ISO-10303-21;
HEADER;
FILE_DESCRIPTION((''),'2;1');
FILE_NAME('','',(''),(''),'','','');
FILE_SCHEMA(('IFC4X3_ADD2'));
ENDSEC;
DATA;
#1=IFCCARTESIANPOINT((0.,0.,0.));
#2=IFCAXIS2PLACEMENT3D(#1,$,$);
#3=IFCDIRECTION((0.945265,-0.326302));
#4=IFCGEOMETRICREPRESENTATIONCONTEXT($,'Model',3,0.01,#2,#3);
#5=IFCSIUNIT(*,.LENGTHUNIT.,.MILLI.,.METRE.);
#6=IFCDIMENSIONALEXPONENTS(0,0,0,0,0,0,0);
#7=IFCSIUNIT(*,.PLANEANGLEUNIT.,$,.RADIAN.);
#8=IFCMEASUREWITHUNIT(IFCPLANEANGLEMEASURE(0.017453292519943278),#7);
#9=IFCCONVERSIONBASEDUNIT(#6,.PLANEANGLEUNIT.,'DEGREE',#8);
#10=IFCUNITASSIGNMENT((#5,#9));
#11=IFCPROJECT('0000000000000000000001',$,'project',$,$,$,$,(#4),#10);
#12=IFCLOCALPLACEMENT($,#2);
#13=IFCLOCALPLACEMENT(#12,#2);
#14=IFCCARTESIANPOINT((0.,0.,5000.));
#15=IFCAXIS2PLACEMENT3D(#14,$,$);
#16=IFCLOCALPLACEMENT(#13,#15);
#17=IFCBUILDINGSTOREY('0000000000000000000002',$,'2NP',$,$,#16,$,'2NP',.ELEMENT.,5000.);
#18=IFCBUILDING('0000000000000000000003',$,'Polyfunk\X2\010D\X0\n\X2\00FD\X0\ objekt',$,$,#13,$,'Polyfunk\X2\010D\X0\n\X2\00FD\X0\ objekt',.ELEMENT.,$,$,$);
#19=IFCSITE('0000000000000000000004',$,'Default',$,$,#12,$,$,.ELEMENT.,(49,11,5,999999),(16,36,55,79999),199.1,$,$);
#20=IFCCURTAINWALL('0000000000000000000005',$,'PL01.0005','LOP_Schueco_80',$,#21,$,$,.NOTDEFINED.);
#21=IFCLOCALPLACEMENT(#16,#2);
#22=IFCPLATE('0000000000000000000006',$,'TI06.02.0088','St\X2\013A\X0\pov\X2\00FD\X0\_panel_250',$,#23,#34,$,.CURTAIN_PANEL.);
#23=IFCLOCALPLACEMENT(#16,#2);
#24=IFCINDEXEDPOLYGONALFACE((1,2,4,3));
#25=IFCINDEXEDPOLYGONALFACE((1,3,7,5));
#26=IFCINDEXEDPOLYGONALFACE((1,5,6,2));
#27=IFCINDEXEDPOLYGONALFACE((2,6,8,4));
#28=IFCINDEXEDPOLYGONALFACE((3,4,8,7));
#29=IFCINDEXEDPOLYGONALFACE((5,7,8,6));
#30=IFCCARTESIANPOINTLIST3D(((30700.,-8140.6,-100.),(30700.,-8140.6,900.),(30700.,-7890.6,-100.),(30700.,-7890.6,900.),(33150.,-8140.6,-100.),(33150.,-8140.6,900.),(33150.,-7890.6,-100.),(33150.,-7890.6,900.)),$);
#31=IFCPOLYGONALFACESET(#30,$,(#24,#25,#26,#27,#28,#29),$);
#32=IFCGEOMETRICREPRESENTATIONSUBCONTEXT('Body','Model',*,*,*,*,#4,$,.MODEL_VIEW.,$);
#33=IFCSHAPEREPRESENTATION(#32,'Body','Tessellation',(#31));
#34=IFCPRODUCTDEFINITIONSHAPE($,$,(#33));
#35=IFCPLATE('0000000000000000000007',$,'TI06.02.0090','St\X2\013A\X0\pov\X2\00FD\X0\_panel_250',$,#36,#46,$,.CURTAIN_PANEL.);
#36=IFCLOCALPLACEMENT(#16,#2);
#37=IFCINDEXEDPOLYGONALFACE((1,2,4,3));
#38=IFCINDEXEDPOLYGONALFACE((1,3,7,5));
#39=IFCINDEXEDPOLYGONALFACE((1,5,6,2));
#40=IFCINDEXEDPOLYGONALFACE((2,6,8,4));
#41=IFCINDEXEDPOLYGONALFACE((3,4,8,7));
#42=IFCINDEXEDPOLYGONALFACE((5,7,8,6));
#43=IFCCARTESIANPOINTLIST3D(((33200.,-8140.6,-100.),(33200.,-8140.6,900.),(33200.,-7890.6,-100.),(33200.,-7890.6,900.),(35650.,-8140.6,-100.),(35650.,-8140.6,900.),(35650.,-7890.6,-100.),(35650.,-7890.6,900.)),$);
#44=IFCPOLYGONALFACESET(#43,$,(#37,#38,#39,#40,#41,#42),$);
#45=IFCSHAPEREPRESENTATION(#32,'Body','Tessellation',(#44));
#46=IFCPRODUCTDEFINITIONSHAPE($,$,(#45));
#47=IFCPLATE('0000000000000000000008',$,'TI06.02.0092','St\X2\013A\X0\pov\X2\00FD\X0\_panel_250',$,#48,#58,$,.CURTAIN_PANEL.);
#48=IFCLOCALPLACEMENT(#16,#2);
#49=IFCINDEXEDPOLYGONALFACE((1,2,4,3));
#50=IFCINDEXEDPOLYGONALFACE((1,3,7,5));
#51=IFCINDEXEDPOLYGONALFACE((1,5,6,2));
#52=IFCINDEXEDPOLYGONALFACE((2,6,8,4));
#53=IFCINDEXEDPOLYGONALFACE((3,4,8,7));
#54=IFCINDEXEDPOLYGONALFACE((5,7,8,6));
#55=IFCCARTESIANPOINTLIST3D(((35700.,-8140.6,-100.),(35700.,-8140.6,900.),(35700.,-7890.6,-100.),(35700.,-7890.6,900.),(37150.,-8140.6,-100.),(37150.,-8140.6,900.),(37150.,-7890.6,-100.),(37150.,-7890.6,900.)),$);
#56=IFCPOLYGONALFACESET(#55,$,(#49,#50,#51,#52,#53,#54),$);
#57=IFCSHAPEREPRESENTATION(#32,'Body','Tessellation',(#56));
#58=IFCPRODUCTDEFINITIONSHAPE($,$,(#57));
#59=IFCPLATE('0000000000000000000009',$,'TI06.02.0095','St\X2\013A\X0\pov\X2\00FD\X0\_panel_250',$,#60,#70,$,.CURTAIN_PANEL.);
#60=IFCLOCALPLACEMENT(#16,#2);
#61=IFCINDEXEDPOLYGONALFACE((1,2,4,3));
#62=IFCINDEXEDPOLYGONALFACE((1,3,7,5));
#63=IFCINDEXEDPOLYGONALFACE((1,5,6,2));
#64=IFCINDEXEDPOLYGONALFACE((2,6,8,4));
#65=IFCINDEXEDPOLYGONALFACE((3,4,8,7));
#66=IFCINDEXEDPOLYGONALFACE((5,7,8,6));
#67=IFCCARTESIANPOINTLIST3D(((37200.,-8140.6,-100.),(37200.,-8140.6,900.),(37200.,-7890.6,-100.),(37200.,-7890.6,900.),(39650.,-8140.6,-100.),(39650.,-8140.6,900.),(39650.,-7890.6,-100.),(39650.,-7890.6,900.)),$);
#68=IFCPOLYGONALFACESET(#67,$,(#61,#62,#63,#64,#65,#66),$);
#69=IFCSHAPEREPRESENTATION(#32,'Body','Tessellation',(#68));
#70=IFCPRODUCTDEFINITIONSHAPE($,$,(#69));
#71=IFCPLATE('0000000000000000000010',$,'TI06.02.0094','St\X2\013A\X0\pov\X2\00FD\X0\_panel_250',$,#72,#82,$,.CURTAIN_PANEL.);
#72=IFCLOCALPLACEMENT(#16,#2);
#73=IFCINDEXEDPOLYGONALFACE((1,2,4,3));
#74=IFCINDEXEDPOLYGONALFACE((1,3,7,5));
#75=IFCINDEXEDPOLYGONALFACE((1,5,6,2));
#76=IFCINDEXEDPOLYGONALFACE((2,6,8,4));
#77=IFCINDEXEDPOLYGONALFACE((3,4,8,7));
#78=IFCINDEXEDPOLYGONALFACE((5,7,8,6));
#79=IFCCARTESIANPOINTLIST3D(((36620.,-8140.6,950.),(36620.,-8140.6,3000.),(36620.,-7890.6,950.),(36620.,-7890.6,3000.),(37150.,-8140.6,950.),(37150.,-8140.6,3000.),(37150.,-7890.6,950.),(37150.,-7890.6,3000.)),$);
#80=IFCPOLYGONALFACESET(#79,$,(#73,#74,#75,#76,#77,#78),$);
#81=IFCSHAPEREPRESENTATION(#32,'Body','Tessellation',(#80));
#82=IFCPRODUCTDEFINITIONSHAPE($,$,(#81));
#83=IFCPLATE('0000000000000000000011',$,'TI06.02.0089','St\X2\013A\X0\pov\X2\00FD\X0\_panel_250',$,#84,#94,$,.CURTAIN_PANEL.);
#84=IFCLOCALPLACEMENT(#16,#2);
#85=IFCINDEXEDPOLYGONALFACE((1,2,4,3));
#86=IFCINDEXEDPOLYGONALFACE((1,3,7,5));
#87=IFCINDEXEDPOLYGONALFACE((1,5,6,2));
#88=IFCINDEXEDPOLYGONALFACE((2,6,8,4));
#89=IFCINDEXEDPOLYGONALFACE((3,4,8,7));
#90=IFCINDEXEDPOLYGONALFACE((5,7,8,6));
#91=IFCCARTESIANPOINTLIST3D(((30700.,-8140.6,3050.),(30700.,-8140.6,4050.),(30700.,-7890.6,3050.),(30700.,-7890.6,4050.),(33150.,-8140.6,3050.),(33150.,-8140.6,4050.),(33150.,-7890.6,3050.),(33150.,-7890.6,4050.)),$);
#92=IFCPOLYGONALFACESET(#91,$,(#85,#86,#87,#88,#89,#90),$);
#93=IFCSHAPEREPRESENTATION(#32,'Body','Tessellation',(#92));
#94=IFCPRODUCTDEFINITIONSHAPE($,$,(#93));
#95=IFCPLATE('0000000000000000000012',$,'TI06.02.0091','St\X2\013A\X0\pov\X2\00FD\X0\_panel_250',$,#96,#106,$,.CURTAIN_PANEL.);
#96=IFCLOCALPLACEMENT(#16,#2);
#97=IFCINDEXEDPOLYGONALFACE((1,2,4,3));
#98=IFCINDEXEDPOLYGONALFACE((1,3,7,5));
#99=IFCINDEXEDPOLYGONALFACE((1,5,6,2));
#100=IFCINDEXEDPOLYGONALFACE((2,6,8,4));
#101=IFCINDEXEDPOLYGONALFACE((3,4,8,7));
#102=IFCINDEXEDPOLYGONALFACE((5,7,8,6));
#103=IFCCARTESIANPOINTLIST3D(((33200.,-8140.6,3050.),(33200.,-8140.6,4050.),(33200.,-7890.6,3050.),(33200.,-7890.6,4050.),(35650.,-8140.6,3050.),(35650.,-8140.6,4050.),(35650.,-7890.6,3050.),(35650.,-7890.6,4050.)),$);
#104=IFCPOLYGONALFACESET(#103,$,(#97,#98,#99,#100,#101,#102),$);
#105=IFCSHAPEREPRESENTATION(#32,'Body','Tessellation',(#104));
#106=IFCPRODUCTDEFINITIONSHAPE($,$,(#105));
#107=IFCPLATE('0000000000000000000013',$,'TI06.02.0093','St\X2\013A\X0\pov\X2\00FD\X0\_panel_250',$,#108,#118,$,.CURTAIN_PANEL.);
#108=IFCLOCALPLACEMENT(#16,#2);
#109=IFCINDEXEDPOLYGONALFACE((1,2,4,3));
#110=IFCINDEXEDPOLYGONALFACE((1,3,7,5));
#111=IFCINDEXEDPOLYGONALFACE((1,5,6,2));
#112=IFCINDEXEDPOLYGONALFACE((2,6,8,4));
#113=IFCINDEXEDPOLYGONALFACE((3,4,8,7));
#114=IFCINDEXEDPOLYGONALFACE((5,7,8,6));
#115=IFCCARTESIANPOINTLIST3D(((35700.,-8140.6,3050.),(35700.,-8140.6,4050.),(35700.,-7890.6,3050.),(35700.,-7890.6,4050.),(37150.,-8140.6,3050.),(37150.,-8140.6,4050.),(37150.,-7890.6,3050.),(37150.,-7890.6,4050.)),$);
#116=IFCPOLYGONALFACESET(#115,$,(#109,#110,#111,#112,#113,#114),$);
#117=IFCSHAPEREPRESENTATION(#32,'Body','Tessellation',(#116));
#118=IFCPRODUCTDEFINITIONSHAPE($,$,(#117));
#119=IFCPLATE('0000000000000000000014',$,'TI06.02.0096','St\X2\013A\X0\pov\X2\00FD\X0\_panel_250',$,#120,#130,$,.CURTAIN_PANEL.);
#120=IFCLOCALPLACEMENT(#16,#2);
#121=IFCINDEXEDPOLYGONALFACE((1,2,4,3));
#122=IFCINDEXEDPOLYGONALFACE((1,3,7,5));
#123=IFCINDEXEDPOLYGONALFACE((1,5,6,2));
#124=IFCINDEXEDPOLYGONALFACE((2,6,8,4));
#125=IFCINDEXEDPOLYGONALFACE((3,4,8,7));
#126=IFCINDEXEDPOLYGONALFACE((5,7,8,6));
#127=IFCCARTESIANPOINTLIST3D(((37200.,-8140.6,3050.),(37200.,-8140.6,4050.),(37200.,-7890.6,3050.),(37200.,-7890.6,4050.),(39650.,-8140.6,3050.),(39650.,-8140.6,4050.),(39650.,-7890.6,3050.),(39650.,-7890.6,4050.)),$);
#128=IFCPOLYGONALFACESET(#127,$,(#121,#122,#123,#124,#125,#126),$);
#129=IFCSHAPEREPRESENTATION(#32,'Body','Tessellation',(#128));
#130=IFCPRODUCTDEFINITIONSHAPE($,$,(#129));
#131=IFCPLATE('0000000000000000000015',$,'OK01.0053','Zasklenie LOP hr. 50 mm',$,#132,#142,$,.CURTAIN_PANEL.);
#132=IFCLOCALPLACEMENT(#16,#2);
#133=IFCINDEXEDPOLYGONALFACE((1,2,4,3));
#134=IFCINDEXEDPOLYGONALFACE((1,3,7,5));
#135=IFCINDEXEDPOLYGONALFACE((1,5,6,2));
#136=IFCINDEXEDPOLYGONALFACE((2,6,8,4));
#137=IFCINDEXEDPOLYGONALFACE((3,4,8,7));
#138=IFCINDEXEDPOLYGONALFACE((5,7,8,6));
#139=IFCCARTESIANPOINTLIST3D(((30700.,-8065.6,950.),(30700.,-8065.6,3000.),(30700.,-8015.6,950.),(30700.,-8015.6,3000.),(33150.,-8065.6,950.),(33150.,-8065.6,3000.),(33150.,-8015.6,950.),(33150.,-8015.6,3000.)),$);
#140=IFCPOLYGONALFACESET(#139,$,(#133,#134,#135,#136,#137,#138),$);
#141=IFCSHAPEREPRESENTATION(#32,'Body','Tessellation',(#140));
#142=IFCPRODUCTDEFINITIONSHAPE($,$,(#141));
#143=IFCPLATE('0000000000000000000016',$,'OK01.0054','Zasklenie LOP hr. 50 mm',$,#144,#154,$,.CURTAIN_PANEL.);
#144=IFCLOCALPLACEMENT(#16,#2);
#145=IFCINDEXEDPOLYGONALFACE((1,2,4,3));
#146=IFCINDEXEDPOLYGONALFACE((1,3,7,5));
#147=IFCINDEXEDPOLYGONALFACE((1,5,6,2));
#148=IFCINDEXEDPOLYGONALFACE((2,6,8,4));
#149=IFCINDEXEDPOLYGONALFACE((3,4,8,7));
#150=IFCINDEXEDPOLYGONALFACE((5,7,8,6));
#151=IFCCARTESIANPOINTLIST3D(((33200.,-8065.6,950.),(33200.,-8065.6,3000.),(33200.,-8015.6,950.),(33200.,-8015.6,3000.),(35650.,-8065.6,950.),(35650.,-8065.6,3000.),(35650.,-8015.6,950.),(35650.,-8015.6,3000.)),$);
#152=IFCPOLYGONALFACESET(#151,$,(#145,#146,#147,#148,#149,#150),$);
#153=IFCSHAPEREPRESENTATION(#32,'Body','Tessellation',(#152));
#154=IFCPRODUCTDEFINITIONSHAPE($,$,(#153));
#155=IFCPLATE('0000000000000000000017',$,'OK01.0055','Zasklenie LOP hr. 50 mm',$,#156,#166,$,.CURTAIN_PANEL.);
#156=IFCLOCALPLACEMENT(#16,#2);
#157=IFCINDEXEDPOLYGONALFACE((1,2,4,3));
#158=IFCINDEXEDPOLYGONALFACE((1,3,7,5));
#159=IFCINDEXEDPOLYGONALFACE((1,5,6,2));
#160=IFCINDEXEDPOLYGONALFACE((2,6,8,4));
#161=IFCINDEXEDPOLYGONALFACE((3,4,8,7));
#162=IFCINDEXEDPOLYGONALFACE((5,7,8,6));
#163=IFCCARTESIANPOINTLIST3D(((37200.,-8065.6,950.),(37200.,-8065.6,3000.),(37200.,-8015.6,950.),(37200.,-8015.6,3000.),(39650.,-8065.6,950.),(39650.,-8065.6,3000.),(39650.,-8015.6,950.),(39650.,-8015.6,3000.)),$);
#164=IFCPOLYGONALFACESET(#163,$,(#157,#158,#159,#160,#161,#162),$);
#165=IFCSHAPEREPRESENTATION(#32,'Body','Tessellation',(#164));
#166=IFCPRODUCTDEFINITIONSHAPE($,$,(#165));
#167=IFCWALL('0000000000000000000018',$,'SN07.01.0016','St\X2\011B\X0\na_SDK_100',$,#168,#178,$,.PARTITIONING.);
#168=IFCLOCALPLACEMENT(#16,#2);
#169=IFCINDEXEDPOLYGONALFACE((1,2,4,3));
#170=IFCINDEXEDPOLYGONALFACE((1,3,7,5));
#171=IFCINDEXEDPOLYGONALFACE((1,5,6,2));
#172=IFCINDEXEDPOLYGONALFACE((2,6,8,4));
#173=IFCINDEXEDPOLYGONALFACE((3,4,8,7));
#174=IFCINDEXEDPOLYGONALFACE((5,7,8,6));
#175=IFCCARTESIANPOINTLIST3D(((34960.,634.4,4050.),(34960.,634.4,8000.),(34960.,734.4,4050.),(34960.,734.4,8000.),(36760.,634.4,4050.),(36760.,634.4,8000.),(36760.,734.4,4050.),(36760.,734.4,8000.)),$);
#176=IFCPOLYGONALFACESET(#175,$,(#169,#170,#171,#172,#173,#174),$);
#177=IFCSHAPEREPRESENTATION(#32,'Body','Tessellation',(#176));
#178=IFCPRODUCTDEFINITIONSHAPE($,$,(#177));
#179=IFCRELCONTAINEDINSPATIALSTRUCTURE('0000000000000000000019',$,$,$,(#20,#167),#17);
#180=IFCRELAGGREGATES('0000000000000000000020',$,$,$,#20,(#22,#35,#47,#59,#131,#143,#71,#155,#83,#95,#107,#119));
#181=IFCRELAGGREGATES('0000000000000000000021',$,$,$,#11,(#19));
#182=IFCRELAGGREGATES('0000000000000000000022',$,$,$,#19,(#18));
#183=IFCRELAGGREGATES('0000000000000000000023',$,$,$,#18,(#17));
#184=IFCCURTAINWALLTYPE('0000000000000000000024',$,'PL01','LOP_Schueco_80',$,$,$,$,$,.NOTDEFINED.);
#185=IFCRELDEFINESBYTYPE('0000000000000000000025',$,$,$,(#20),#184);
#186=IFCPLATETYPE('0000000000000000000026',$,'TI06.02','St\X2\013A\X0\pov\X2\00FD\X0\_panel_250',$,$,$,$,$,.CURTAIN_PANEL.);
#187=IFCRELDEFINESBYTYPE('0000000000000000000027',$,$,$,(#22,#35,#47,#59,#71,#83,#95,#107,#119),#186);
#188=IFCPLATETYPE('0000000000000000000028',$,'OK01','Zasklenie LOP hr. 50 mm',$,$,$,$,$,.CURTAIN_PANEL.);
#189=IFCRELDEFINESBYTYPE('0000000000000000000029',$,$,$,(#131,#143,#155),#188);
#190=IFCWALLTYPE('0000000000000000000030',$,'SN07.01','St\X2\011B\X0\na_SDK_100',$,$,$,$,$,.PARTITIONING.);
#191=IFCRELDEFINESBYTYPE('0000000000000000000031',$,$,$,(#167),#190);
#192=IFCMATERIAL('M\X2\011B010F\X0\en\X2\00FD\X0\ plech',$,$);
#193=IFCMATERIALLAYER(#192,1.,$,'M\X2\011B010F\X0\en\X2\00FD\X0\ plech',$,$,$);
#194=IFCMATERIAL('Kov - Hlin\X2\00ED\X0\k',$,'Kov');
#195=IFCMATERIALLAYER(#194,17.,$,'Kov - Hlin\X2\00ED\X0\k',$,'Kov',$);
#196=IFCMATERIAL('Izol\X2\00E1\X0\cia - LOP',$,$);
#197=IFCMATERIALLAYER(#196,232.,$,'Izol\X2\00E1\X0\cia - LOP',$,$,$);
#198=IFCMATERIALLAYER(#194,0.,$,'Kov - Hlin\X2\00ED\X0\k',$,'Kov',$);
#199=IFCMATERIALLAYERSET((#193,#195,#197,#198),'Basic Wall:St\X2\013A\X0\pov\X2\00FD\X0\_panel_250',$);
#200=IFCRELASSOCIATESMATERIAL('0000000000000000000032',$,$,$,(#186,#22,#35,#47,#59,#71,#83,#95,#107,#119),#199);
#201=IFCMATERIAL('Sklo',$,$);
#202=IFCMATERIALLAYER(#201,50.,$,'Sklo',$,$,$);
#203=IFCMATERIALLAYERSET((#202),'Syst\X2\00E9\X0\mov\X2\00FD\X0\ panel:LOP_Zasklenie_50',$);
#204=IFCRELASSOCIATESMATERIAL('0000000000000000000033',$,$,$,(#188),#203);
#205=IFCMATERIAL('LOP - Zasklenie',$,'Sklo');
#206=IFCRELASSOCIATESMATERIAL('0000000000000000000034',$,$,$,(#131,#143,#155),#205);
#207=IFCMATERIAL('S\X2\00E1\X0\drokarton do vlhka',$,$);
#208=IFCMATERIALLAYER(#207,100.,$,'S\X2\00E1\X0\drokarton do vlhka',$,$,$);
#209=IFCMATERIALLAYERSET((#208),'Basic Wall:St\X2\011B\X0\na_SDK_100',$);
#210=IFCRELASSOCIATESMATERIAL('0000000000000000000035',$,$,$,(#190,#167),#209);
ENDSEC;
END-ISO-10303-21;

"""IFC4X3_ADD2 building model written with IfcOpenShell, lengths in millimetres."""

from ifc_helpers import new_model, entity, si_unit, converted_unit, direction, frame, frame_2d, origin, origin_2d_with_axis, place, context, subcontext, project, spatial, polyline, rectangle, extrude, clip, bounded_halfspace, source, transform, mapped, material, layer, layer_set, layer_usage, type_object, type_shapes, element, aggregate, save


model = new_model("IFC4X3_ADD2")

# Units and contexts
model_context = context("Model", 3, precision=0.01, world=origin(), true_north=direction((0.945265, -0.326302)))
body_context = subcontext(model_context, "Body", "Model", "MODEL_VIEW")
ifc_project = project(units=[si_unit("LENGTHUNIT", "METRE", prefix="MILLI"), converted_unit("PLANEANGLEUNIT", "DEGREE", entity("IfcPlaneAngleMeasure", 0.017453292519943278), si_unit("PLANEANGLEUNIT", "RADIAN"), dimensions=[0, 0, 0, 0, 0, 0, 0])], contexts=[model_context])

# Site, building, storey
site_placement = place(None, origin())
site = spatial("IfcSite", under=ifc_project, at=site_placement, Name="Default", CompositionType="ELEMENT", RefLatitude=(49, 11, 5, 999999), RefLongitude=(16, 36, 55, 79999), RefElevation=199.1)
building_placement = place(site_placement, origin())
building = spatial("IfcBuilding", under=site, at=building_placement, Name="Polyfunkčný objekt", LongName="Polyfunkčný objekt", CompositionType="ELEMENT")
storey_placement = place(building_placement, frame((0.0, 0.0, 5000.0)))
storey = spatial("IfcBuildingStorey", under=building, at=storey_placement, Name="2NP", LongName="2NP", CompositionType="ELEMENT", Elevation=5000.0)

# Curtain wall, plates
curtain_wall_type = type_object("IfcCurtainWallType", Name="PL01", Description="LOP_Schueco_80", PredefinedType="NOTDEFINED")
curtain_wall_placement = place(storey_placement, frame((0.0, 0.0, -5000.0)))
curtain_wall = element("IfcCurtainWall", 1, at=curtain_wall_placement, inside=storey, type_object=curtain_wall_type, Name="PL01.0005", Description="LOP_Schueco_80", PredefinedType="NOTDEFINED")
ifc_material_1 = material(Name="Měďený plech")
ifc_layer_1 = layer(ifc_material_1, 1.0, Name="Měďený plech")
ifc_material_2 = material(Name="Kov - Hliník", Category="Kov")
ifc_layer_2 = layer(ifc_material_2, 17.0, Name="Kov - Hliník", Category="Kov")
ifc_material_3 = material(Name="Izolácia - LOP")
ifc_layer_3 = layer(ifc_material_3, 232.0, Name="Izolácia - LOP")
ifc_layer_4 = layer(ifc_material_2, 0.0, Name="Kov - Hliník", Category="Kov")
ifc_layer_set_1 = layer_set([ifc_layer_1, ifc_layer_2, ifc_layer_3, ifc_layer_4], Name="Basic Wall:Stĺpový_panel_250")
ifc_layer_usage_1 = layer_usage(ifc_layer_set_1, "AXIS2", "POSITIVE", -125.0)
plate_type_1 = type_object("IfcPlateType", Name="TI06.02", Description="Stĺpový_panel_250", PredefinedType="CURTAIN_PANEL", material=ifc_layer_set_1)
plate_1_placement = place(storey_placement, frame((30700.0, -8015.6, -100.0)))
plate_1 = element("IfcPlate", 2, at=plate_1_placement, type_object=plate_type_1, material=ifc_layer_usage_1, Name="TI06.02.0088", Description="Stĺpový_panel_250", PredefinedType="CURTAIN_PANEL", context=body_context, shape_type="SweptSolid", body=[
    extrude(rectangle(XDim=250.0, YDim=2450.0, at=frame_2d((0.0, 0.0), x_axis=(1.0, 0.0))), frame((1225.0, 0.0, 0.0), z_axis=(0.0, 0.0, 1.0), x_axis=(0.0, 1.0, 0.0)), (0.0, 0.0, 1.0), 1000.0),
])
ifc_layer_usage_2 = layer_usage(ifc_layer_set_1, "AXIS2", "POSITIVE", -125.0)
plate_2_placement = place(storey_placement, frame((33200.0, -8015.6, -100.0)))
plate_2 = element("IfcPlate", 3, at=plate_2_placement, type_object=plate_type_1, material=ifc_layer_usage_2, Name="TI06.02.0090", Description="Stĺpový_panel_250", PredefinedType="CURTAIN_PANEL", context=body_context, shape_type="SweptSolid", body=[
    extrude(rectangle(XDim=250.0, YDim=2450.0, at=frame_2d((0.0, 0.0), x_axis=(1.0, 0.0))), frame((1225.0, 0.0, 0.0), z_axis=(0.0, 0.0, 1.0), x_axis=(0.0, 1.0, 0.0)), (0.0, 0.0, 1.0), 1000.0),
])
ifc_layer_usage_3 = layer_usage(ifc_layer_set_1, "AXIS2", "POSITIVE", -125.0)
plate_3_placement = place(storey_placement, frame((35700.0, -8015.6, -100.0)))
plate_3 = element("IfcPlate", 4, at=plate_3_placement, type_object=plate_type_1, material=ifc_layer_usage_3, Name="TI06.02.0092", Description="Stĺpový_panel_250", PredefinedType="CURTAIN_PANEL", context=body_context, shape_type="SweptSolid", body=[
    extrude(rectangle(XDim=250.0, YDim=1450.0, at=frame_2d((0.0, 0.0), x_axis=(1.0, 0.0))), frame((725.0, 0.0, 0.0), z_axis=(0.0, 0.0, 1.0), x_axis=(0.0, 1.0, 0.0)), (0.0, 0.0, 1.0), 1000.0),
])
ifc_layer_usage_4 = layer_usage(ifc_layer_set_1, "AXIS2", "POSITIVE", -125.0)
plate_4_placement = place(storey_placement, frame((37200.0, -8015.6, -100.0)))
plate_4 = element("IfcPlate", 5, at=plate_4_placement, type_object=plate_type_1, material=ifc_layer_usage_4, Name="TI06.02.0095", Description="Stĺpový_panel_250", PredefinedType="CURTAIN_PANEL", context=body_context, shape_type="SweptSolid", body=[
    extrude(rectangle(XDim=250.0, YDim=2450.0, at=frame_2d((0.0, 0.0), x_axis=(1.0, 0.0))), frame((1225.0, 0.0, 0.0), z_axis=(0.0, 0.0, 1.0), x_axis=(0.0, 1.0, 0.0)), (0.0, 0.0, 1.0), 1000.0),
])
ifc_layer_usage_5 = layer_usage(ifc_layer_set_1, "AXIS2", "POSITIVE", -125.0)
plate_5_placement = place(storey_placement, frame((36620.0, -8015.6, 950.0)))
plate_5 = element("IfcPlate", 6, at=plate_5_placement, type_object=plate_type_1, material=ifc_layer_usage_5, Name="TI06.02.0094", Description="Stĺpový_panel_250", PredefinedType="CURTAIN_PANEL", context=body_context, shape_type="SweptSolid", body=[
    extrude(rectangle(XDim=250.0, YDim=530.0, at=frame_2d((0.0, 0.0), x_axis=(1.0, 0.0))), frame((265.0, 0.0, 0.0), z_axis=(0.0, 0.0, 1.0), x_axis=(0.0, 1.0, 0.0)), (0.0, 0.0, 1.0), 2050.0),
])
ifc_layer_usage_6 = layer_usage(ifc_layer_set_1, "AXIS2", "POSITIVE", -125.0)
plate_6_placement = place(storey_placement, frame((30700.0, -8015.6, 3050.0)))
plate_6 = element("IfcPlate", 7, at=plate_6_placement, type_object=plate_type_1, material=ifc_layer_usage_6, Name="TI06.02.0089", Description="Stĺpový_panel_250", PredefinedType="CURTAIN_PANEL", context=body_context, shape_type="SweptSolid", body=[
    extrude(rectangle(XDim=250.0, YDim=2450.0, at=frame_2d((0.0, 0.0), x_axis=(1.0, 0.0))), frame((1225.0, 0.0, 0.0), z_axis=(0.0, 0.0, 1.0), x_axis=(0.0, 1.0, 0.0)), (0.0, 0.0, 1.0), 1000.0),
])
ifc_layer_usage_7 = layer_usage(ifc_layer_set_1, "AXIS2", "POSITIVE", -125.0)
plate_7_placement = place(storey_placement, frame((33200.0, -8015.6, 3050.0)))
plate_7 = element("IfcPlate", 8, at=plate_7_placement, type_object=plate_type_1, material=ifc_layer_usage_7, Name="TI06.02.0091", Description="Stĺpový_panel_250", PredefinedType="CURTAIN_PANEL", context=body_context, shape_type="SweptSolid", body=[
    extrude(rectangle(XDim=250.0, YDim=2450.0, at=frame_2d((0.0, 0.0), x_axis=(1.0, 0.0))), frame((1225.0, 0.0, 0.0), z_axis=(0.0, 0.0, 1.0), x_axis=(0.0, 1.0, 0.0)), (0.0, 0.0, 1.0), 1000.0),
])
ifc_layer_usage_8 = layer_usage(ifc_layer_set_1, "AXIS2", "POSITIVE", -125.0)
plate_8_placement = place(storey_placement, frame((35700.0, -8015.6, 3050.0)))
plate_8 = element("IfcPlate", 9, at=plate_8_placement, type_object=plate_type_1, material=ifc_layer_usage_8, Name="TI06.02.0093", Description="Stĺpový_panel_250", PredefinedType="CURTAIN_PANEL", context=body_context, shape_type="SweptSolid", body=[
    extrude(rectangle(XDim=250.0, YDim=1450.0, at=frame_2d((0.0, 0.0), x_axis=(1.0, 0.0))), frame((725.0, 0.0, 0.0), z_axis=(0.0, 0.0, 1.0), x_axis=(0.0, 1.0, 0.0)), (0.0, 0.0, 1.0), 1000.0),
])
ifc_layer_usage_9 = layer_usage(ifc_layer_set_1, "AXIS2", "POSITIVE", -125.0)
plate_9_placement = place(storey_placement, frame((37200.0, -8015.6, 3050.0)))
plate_9 = element("IfcPlate", 10, at=plate_9_placement, type_object=plate_type_1, material=ifc_layer_usage_9, Name="TI06.02.0096", Description="Stĺpový_panel_250", PredefinedType="CURTAIN_PANEL", context=body_context, shape_type="SweptSolid", body=[
    extrude(rectangle(XDim=250.0, YDim=2450.0, at=frame_2d((0.0, 0.0), x_axis=(1.0, 0.0))), frame((1225.0, 0.0, 0.0), z_axis=(0.0, 0.0, 1.0), x_axis=(0.0, 1.0, 0.0)), (0.0, 0.0, 1.0), 1000.0),
])
ifc_material_4 = material(Name="LOP - Zasklenie", Category="Sklo")
ifc_material_5 = material(Name="Sklo")
ifc_layer_5 = layer(ifc_material_5, 50.0, Name="Sklo")
ifc_layer_set_2 = layer_set([ifc_layer_5], Name="Systémový panel:LOP_Zasklenie_50")
plate_type_2 = type_object("IfcPlateType", Name="OK01", Description="Zasklenie LOP hr. 50 mm", PredefinedType="CURTAIN_PANEL", material=ifc_layer_set_2)
shared_shape_1 = source(origin(), body_context, "Body", "SweptSolid", [
    extrude(rectangle(XDim=50.0, YDim=2450.0, at=origin_2d_with_axis()), frame((0.0, -25.0, 0.0), z_axis=(0.0, 0.0, 1.0), x_axis=(0.0, 1.0, 0.0)), (0.0, 0.0, 1.0), 2050.0),
])
type_shapes(plate_type_2, [shared_shape_1])
plate_10_placement = place(curtain_wall_placement, frame((31925.0, -8015.6, 5950.0)))
plate_10 = element("IfcPlate", 11, at=plate_10_placement, type_object=plate_type_2, material=ifc_material_4, Name="OK01.0053", Description="Zasklenie LOP hr. 50 mm", PredefinedType="CURTAIN_PANEL", context=body_context, shape_type="MappedRepresentation", body=[
    mapped(shared_shape_1, transform((0.0, 0.0, 0.0), scale=1.0)),
])
plate_11_placement = place(curtain_wall_placement, frame((34425.0, -8015.6, 5950.0)))
plate_11 = element("IfcPlate", 12, at=plate_11_placement, type_object=plate_type_2, material=ifc_material_4, Name="OK01.0054", Description="Zasklenie LOP hr. 50 mm", PredefinedType="CURTAIN_PANEL", context=body_context, shape_type="MappedRepresentation", body=[
    mapped(shared_shape_1, transform((0.0, 0.0, 0.0), scale=1.0)),
])
plate_12_placement = place(curtain_wall_placement, frame((38425.0, -8015.6, 5950.0)))
plate_12 = element("IfcPlate", 13, at=plate_12_placement, type_object=plate_type_2, material=ifc_material_4, Name="OK01.0055", Description="Zasklenie LOP hr. 50 mm", PredefinedType="CURTAIN_PANEL", context=body_context, shape_type="MappedRepresentation", body=[
    mapped(shared_shape_1, transform((0.0, 0.0, 0.0), scale=1.0)),
])

# Wall
ifc_material_6 = material(Name="Sádrokarton do vlhka")
ifc_layer_6 = layer(ifc_material_6, 100.0, Name="Sádrokarton do vlhka")
ifc_layer_set_3 = layer_set([ifc_layer_6], Name="Basic Wall:Stěna_SDK_100")
wall_type_1 = type_object("IfcWallType", Name="SN07.01", Description="Stěna_SDK_100", PredefinedType="PARTITIONING", material=ifc_layer_set_3)
wall_1_placement = place(storey_placement, frame((34960.0, 684.4, 4050.0)))
element("IfcWall", 14, at=wall_1_placement, inside=storey, type_object=wall_type_1, material=ifc_layer_set_3, Name="SN07.01.0016", Description="Stěna_SDK_100", PredefinedType="PARTITIONING", context=body_context, shape_type="Clipping", body=[
    clip(clip(extrude(rectangle(XDim=1800.0, YDim=100.0, at=frame_2d((900.0, 0.0), x_axis=(-1.0, 0.0))), origin(), (0.0, 0.0, 1.0), 3950.0), bounded_halfspace(frame((1800.0, -50.0, 0.0), z_axis=(0.0, 0.0, 1.0), x_axis=(-1.0, 0.0, 0.0)), True, frame((1800.0, -50.0, 0.0)), polyline([(0.0, 0.0), (0.0, 100.0), (-1800.0, 100.0), (-1800.0, 0.0), (0.0, 0.0)]))), bounded_halfspace(frame((0.0, -50.0, 3950.0), z_axis=(0.0, 0.0, -1.0), x_axis=(1.0, 0.0, 0.0)), True, frame((0.0, -50.0, 3950.0)), polyline([(0.0, 0.0), (1800.0, 0.0), (1800.0, 100.0), (0.0, 100.0), (0.0, 0.0)]))),
])

aggregate(curtain_wall, [plate_1, plate_2, plate_3, plate_4, plate_10, plate_11, plate_5, plate_12, plate_6, plate_7, plate_8, plate_9])

save(model, "model.ifc")
